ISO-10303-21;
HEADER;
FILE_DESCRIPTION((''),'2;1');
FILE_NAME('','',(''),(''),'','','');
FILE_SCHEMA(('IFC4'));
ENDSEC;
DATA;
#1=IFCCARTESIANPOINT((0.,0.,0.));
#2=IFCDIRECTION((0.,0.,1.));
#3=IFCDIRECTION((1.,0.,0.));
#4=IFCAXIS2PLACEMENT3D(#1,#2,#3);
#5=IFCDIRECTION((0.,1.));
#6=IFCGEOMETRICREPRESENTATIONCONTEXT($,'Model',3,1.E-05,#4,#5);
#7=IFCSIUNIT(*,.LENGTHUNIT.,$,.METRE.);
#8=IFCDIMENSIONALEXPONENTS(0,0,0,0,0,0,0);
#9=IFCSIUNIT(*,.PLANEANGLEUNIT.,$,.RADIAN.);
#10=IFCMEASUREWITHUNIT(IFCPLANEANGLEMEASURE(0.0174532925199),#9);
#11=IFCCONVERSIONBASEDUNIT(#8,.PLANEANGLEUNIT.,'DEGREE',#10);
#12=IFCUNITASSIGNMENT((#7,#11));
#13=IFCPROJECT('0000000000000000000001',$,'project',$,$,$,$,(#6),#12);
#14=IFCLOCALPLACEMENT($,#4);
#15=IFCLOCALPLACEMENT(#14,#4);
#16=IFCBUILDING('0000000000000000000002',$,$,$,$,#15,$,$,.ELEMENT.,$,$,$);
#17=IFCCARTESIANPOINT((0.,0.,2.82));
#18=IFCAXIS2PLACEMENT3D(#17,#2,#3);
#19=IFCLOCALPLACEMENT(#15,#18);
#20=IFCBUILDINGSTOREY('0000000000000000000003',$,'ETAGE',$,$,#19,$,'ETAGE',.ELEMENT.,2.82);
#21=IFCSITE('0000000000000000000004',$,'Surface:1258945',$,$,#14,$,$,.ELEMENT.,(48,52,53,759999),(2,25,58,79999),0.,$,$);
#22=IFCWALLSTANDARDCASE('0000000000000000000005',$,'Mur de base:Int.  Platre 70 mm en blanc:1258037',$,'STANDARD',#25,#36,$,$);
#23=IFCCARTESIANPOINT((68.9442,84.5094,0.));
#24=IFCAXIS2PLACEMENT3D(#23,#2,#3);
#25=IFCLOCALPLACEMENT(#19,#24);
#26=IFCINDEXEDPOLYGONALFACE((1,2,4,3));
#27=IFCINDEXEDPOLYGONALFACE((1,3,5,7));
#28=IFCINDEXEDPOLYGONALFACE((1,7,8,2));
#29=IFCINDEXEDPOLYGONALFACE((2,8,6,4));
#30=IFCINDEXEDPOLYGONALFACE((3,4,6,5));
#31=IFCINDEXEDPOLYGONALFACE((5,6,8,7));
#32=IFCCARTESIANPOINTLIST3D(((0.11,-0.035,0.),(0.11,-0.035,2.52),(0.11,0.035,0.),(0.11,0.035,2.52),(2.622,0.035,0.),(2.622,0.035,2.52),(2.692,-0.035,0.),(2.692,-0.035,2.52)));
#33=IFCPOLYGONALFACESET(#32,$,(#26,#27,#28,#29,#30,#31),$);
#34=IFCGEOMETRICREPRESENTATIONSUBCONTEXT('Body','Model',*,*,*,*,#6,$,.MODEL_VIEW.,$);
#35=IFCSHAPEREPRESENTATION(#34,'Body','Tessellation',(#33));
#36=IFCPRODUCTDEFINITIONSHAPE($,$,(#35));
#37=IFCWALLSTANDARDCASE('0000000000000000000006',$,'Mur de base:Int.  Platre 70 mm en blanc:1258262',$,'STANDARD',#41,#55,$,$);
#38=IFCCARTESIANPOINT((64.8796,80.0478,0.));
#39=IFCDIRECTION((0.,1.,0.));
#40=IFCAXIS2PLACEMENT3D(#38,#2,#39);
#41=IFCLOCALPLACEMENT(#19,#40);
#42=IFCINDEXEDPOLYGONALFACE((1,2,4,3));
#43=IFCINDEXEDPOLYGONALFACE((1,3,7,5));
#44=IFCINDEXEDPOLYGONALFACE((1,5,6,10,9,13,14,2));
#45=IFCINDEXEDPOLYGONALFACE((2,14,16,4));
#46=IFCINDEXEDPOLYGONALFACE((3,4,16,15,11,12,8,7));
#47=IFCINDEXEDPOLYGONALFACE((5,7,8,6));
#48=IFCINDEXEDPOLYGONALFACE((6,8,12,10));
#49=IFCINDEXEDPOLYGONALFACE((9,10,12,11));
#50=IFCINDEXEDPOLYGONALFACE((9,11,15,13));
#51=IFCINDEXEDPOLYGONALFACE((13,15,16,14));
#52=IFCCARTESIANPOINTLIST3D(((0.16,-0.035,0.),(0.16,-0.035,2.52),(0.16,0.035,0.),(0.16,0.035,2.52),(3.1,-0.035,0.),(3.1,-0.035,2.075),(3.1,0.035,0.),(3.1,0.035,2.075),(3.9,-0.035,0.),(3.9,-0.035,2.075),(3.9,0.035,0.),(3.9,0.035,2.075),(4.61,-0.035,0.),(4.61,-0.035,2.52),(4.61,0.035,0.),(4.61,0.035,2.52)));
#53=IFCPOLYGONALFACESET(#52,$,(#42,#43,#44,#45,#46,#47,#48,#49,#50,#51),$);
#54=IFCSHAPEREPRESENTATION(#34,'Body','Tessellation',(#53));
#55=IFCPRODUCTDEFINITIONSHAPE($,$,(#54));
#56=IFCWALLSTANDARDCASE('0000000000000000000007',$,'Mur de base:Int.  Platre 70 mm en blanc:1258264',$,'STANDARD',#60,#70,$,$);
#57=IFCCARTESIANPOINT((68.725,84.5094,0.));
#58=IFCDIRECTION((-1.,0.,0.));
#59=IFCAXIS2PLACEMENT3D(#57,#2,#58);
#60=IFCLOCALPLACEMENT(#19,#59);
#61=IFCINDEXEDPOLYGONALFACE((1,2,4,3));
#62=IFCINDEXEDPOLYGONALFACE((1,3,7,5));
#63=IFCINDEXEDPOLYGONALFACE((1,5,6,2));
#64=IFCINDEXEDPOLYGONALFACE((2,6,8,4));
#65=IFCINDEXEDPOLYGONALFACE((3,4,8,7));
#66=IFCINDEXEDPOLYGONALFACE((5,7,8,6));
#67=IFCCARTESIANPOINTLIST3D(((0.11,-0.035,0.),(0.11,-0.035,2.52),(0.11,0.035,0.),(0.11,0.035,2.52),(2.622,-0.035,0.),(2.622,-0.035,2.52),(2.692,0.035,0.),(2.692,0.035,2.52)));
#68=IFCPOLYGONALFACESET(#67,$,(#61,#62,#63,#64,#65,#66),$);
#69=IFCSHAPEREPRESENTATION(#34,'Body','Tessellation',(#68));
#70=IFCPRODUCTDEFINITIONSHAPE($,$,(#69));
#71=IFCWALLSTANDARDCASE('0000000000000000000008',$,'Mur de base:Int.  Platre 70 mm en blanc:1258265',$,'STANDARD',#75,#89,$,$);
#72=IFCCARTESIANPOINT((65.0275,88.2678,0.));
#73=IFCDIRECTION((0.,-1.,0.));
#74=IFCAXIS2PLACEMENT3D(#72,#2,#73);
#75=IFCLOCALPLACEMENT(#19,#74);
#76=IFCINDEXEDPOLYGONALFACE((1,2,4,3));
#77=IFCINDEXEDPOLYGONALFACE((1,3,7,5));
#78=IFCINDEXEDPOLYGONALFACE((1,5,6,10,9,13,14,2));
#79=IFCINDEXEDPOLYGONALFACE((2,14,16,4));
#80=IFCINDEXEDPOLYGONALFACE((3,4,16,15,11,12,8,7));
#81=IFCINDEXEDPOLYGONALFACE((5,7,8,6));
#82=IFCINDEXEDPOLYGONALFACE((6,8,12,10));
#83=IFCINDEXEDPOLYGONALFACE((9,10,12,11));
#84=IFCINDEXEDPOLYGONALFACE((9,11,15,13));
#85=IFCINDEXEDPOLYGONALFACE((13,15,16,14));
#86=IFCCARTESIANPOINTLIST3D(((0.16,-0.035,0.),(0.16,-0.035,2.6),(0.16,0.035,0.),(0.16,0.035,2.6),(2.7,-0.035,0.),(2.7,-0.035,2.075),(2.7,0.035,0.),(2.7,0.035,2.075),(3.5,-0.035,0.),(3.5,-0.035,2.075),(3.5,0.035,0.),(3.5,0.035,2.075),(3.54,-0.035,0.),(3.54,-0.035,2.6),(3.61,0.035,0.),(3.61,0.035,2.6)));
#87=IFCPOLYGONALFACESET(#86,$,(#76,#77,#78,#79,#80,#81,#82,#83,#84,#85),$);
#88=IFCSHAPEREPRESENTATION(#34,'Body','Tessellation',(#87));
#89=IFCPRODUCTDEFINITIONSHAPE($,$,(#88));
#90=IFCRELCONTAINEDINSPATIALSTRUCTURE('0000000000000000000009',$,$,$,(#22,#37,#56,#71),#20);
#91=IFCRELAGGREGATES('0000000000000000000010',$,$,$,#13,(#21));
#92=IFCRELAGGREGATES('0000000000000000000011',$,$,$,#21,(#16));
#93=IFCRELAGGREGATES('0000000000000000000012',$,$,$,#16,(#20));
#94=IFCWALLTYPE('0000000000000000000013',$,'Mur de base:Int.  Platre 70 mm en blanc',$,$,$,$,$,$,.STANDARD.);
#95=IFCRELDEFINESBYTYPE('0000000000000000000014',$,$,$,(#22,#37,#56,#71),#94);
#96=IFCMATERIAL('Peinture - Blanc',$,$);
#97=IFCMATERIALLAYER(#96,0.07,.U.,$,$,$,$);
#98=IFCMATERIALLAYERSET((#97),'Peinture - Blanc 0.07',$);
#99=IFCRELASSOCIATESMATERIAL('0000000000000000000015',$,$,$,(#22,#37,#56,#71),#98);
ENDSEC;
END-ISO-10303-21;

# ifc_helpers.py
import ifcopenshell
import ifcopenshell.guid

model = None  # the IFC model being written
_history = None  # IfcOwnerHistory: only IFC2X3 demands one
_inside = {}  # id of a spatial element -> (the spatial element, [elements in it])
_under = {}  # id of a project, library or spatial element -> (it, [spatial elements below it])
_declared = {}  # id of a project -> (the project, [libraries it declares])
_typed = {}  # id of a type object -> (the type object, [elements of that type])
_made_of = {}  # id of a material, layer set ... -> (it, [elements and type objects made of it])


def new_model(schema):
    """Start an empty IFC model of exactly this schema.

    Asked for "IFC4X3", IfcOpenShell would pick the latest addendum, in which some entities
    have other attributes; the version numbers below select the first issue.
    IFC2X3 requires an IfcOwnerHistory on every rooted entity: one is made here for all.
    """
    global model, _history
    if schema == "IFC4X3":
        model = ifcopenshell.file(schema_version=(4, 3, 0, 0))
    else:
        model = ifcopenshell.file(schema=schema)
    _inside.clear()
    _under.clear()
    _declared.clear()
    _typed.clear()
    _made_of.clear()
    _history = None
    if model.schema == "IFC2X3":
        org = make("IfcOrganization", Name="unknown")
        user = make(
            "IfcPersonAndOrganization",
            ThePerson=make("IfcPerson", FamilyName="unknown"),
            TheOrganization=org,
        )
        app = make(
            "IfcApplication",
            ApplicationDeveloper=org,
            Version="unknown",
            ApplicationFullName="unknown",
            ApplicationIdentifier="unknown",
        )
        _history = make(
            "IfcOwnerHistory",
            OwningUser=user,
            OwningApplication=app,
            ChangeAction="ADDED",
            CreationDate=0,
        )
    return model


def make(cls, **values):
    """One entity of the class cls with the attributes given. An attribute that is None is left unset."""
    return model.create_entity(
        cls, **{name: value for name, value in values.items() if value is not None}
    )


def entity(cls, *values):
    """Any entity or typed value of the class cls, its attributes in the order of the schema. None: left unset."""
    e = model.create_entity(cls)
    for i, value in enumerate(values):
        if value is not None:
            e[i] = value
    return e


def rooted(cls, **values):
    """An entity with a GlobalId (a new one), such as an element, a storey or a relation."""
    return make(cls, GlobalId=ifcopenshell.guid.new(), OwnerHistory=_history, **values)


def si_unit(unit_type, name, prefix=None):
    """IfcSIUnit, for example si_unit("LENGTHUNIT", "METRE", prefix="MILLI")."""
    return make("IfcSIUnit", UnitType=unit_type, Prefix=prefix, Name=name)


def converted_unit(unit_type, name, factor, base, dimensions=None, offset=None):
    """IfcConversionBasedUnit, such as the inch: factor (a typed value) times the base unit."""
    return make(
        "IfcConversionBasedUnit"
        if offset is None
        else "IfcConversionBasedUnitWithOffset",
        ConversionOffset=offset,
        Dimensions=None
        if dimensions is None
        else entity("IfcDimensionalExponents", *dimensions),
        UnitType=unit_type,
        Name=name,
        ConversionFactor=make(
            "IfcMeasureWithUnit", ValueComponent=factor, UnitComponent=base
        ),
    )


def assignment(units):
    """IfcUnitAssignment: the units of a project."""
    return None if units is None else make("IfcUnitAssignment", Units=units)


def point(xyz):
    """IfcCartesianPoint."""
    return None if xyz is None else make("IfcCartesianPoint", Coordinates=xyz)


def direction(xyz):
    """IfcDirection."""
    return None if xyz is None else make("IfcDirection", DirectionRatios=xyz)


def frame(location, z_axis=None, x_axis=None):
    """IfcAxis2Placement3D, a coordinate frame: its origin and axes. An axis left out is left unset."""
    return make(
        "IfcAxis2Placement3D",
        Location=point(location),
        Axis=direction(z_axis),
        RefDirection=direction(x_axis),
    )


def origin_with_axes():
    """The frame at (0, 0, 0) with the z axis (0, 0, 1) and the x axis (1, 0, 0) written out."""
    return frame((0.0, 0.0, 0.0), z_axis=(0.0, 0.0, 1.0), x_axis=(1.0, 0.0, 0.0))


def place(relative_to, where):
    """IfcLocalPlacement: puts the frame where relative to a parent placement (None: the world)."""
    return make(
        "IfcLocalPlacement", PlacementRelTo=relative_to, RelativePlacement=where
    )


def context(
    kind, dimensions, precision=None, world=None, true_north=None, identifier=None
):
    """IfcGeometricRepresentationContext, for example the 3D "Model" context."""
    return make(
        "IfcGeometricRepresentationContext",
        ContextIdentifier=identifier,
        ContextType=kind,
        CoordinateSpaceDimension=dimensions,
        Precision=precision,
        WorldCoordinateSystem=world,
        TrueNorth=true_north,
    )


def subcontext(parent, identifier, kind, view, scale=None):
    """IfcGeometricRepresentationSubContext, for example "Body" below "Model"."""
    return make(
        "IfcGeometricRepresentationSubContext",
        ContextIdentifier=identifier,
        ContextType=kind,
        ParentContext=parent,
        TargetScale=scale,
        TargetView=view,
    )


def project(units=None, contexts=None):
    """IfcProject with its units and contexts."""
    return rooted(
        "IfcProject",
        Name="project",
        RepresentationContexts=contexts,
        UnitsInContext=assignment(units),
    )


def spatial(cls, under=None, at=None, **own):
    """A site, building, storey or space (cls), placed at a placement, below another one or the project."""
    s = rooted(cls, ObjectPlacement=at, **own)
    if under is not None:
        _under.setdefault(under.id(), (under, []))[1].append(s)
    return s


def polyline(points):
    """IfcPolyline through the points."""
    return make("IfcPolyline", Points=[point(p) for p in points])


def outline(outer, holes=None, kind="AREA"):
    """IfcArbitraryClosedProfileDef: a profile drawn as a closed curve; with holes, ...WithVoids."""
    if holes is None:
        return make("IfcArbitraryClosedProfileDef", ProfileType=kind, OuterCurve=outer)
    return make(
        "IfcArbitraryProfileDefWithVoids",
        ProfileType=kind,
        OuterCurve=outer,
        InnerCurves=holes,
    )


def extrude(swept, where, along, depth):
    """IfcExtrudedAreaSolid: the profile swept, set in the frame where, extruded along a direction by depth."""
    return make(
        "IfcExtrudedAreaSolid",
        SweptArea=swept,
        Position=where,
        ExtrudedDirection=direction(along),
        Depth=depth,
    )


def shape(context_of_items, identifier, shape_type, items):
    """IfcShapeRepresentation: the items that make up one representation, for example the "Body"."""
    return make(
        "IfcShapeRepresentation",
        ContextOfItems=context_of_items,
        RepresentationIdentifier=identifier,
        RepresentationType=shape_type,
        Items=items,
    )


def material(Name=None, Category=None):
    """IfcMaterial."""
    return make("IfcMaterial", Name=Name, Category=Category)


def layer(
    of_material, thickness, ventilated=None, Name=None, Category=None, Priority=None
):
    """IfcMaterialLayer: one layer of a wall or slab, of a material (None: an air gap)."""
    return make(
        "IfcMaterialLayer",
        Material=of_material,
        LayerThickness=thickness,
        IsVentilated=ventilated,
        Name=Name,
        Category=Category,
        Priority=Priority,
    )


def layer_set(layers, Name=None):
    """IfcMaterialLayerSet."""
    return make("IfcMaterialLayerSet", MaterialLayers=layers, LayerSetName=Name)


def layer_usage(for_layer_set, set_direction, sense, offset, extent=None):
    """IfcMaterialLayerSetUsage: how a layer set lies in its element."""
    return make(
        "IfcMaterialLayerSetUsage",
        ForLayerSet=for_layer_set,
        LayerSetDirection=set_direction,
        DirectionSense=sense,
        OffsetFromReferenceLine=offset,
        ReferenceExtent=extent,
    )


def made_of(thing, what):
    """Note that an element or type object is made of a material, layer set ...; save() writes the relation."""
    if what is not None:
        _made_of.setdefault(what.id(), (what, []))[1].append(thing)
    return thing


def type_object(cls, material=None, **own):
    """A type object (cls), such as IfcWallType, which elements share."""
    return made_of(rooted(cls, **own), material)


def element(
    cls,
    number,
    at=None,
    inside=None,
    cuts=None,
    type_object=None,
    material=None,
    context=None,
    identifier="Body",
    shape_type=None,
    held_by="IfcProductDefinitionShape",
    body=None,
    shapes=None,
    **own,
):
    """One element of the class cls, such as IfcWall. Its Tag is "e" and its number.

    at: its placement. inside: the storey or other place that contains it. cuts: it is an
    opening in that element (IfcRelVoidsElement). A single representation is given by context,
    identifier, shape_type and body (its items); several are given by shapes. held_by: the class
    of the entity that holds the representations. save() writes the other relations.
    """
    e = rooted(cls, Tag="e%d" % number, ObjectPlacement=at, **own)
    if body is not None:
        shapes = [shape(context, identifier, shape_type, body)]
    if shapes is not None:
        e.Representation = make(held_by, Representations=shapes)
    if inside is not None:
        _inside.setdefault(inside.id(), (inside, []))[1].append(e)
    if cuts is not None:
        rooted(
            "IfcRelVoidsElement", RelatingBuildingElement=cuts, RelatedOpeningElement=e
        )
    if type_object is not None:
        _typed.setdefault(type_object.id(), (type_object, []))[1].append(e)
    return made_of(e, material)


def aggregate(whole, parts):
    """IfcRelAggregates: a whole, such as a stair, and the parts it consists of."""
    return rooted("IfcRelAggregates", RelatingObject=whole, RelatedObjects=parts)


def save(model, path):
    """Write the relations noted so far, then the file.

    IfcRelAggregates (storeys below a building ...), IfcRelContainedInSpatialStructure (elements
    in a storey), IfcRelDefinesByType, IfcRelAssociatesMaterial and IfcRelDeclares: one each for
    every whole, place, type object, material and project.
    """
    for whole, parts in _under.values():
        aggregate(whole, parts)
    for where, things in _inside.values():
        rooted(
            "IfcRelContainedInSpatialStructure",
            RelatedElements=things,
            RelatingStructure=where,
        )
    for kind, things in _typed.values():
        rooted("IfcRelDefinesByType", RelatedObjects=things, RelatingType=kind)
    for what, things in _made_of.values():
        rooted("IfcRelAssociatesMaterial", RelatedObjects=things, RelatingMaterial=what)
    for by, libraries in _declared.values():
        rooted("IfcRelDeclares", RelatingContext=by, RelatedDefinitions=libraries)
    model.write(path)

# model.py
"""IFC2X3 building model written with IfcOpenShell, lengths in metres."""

from ifc_helpers import new_model, entity, si_unit, converted_unit, direction, frame, origin_with_axes, place, context, subcontext, project, spatial, polyline, outline, extrude, material, layer, layer_set, layer_usage, type_object, element, save


model = new_model("IFC2X3")

# Units and contexts
model_context = context("Model", 3, precision=1e-05, world=origin_with_axes(), true_north=direction((0.0, 1.0)))
body_context = subcontext(model_context, "Body", "Model", "MODEL_VIEW")
ifc_project = project(units=[si_unit("LENGTHUNIT", "METRE"), converted_unit("PLANEANGLEUNIT", "DEGREE", entity("IfcPlaneAngleMeasure", 0.0174532925199), si_unit("PLANEANGLEUNIT", "RADIAN"), dimensions=[0, 0, 0, 0, 0, 0, 0])], contexts=[model_context])

# Site, building, storey
site_placement = place(None, origin_with_axes())
site = spatial("IfcSite", under=ifc_project, at=site_placement, Name="Surface:1258945", CompositionType="ELEMENT", RefLatitude=(48, 52, 53, 759999), RefLongitude=(2, 25, 58, 79999), RefElevation=0.0)
building_placement = place(site_placement, origin_with_axes())
building = spatial("IfcBuilding", under=site, at=building_placement, CompositionType="ELEMENT")
storey_placement = place(building_placement, frame((0.0, 0.0, 2.82), z_axis=(0.0, 0.0, 1.0), x_axis=(1.0, 0.0, 0.0)))
storey = spatial("IfcBuildingStorey", under=building, at=storey_placement, Name="ETAGE", LongName="ETAGE", CompositionType="ELEMENT", Elevation=2.82)

# Wall
ifc_material_1 = material(Name="Peinture - Blanc")
ifc_layer_1 = layer(ifc_material_1, 0.07, ventilated="UNKNOWN")
ifc_layer_set_1 = layer_set([ifc_layer_1], Name="Peinture - Blanc 0.07")
ifc_layer_usage_1 = layer_usage(ifc_layer_set_1, "AXIS2", "POSITIVE", -0.035)
wall_type_1 = type_object("IfcWallType", Name="Mur de base:Int.  Platre 70 mm en blanc", PredefinedType="STANDARD")
wall_1_placement = place(storey_placement, frame((68.9442, 84.5094, 0.0), z_axis=(0.0, 0.0, 1.0), x_axis=(1.0, 0.0, 0.0)))
element("IfcWallStandardCase", 1, at=wall_1_placement, inside=storey, type_object=wall_type_1, material=ifc_layer_usage_1, Name="Mur de base:Int.  Platre 70 mm en blanc:1258037", ObjectType="STANDARD", context=body_context, shape_type="SweptSolid", body=[
    extrude(outline(polyline([(0.11, -0.035), (2.692, -0.035), (2.622, 0.035), (0.11, 0.035), (0.11, -0.035)])), origin_with_axes(), (0.0, 0.0, 1.0), 2.52),
])

# Wall, opening
ifc_layer_usage_2 = layer_usage(ifc_layer_set_1, "AXIS2", "POSITIVE", -0.035)
wall_2_placement = place(storey_placement, frame((64.8796, 80.0478, 0.0), z_axis=(0.0, 0.0, 1.0), x_axis=(0.0, 1.0, 0.0)))
wall_2 = element("IfcWallStandardCase", 2, at=wall_2_placement, inside=storey, type_object=wall_type_1, material=ifc_layer_usage_2, Name="Mur de base:Int.  Platre 70 mm en blanc:1258262", ObjectType="STANDARD", context=body_context, shape_type="SweptSolid", body=[
    extrude(outline(polyline([(0.16, -0.035), (4.61, -0.035), (4.61, 0.035), (0.16, 0.035), (0.16, -0.035)])), origin_with_axes(), (0.0, 0.0, 1.0), 2.52),
])
opening_1_placement = place(wall_2_placement, frame((3.5, 0.0, 0.0), z_axis=(0.0, 0.0, 1.0), x_axis=(1.0, 0.0, 0.0)))
element("IfcOpeningElement", 3, at=opening_1_placement, cuts=wall_2, context=body_context, shape_type="SweptSolid", body=[
    extrude(outline(polyline([(0.4, 0.0), (0.4, 2.075), (-0.4, 2.075), (-0.4, 0.0), (0.4, 0.0)])), frame((0.0, -0.035, 0.0), z_axis=(0.0, 1.0, 0.0), x_axis=(-1.0, 0.0, 0.0)), (0.0, 0.0, 1.0), 0.07),
])

# Wall
ifc_layer_usage_3 = layer_usage(ifc_layer_set_1, "AXIS2", "POSITIVE", -0.035)
wall_3_placement = place(storey_placement, frame((68.725, 84.5094, 0.0), z_axis=(0.0, 0.0, 1.0), x_axis=(-1.0, 0.0, 0.0)))
element("IfcWallStandardCase", 4, at=wall_3_placement, inside=storey, type_object=wall_type_1, material=ifc_layer_usage_3, Name="Mur de base:Int.  Platre 70 mm en blanc:1258264", ObjectType="STANDARD", context=body_context, shape_type="SweptSolid", body=[
    extrude(outline(polyline([(0.11, -0.035), (2.622, -0.035), (2.692, 0.035), (0.11, 0.035), (0.11, -0.035)])), origin_with_axes(), (0.0, 0.0, 1.0), 2.52),
])

# Wall, opening
ifc_layer_usage_4 = layer_usage(ifc_layer_set_1, "AXIS2", "POSITIVE", -0.035)
wall_4_placement = place(storey_placement, frame((65.0275, 88.2678, 0.0), z_axis=(0.0, 0.0, 1.0), x_axis=(0.0, -1.0, 0.0)))
wall_4 = element("IfcWallStandardCase", 5, at=wall_4_placement, inside=storey, type_object=wall_type_1, material=ifc_layer_usage_4, Name="Mur de base:Int.  Platre 70 mm en blanc:1258265", ObjectType="STANDARD", context=body_context, shape_type="SweptSolid", body=[
    extrude(outline(polyline([(0.16, -0.035), (3.54, -0.035), (3.61, 0.035), (0.16, 0.035), (0.16, -0.035)])), origin_with_axes(), (0.0, 0.0, 1.0), 2.6),
])
opening_2_placement = place(wall_4_placement, frame((3.1, 0.0, 0.0), z_axis=(0.0, 0.0, 1.0), x_axis=(1.0, 0.0, 0.0)))
element("IfcOpeningElement", 6, at=opening_2_placement, cuts=wall_4, context=body_context, shape_type="SweptSolid", body=[
    extrude(outline(polyline([(-0.4, 0.0), (0.4, 0.0), (0.4, 2.075), (-0.4, 2.075), (-0.4, 0.0)])), frame((0.0, 0.035, 0.0), z_axis=(0.0, 1.0, 0.0), x_axis=(-1.0, 0.0, 0.0)), (0.0, 0.0, -1.0), 0.07),
])

save(model, "model.ifc")
